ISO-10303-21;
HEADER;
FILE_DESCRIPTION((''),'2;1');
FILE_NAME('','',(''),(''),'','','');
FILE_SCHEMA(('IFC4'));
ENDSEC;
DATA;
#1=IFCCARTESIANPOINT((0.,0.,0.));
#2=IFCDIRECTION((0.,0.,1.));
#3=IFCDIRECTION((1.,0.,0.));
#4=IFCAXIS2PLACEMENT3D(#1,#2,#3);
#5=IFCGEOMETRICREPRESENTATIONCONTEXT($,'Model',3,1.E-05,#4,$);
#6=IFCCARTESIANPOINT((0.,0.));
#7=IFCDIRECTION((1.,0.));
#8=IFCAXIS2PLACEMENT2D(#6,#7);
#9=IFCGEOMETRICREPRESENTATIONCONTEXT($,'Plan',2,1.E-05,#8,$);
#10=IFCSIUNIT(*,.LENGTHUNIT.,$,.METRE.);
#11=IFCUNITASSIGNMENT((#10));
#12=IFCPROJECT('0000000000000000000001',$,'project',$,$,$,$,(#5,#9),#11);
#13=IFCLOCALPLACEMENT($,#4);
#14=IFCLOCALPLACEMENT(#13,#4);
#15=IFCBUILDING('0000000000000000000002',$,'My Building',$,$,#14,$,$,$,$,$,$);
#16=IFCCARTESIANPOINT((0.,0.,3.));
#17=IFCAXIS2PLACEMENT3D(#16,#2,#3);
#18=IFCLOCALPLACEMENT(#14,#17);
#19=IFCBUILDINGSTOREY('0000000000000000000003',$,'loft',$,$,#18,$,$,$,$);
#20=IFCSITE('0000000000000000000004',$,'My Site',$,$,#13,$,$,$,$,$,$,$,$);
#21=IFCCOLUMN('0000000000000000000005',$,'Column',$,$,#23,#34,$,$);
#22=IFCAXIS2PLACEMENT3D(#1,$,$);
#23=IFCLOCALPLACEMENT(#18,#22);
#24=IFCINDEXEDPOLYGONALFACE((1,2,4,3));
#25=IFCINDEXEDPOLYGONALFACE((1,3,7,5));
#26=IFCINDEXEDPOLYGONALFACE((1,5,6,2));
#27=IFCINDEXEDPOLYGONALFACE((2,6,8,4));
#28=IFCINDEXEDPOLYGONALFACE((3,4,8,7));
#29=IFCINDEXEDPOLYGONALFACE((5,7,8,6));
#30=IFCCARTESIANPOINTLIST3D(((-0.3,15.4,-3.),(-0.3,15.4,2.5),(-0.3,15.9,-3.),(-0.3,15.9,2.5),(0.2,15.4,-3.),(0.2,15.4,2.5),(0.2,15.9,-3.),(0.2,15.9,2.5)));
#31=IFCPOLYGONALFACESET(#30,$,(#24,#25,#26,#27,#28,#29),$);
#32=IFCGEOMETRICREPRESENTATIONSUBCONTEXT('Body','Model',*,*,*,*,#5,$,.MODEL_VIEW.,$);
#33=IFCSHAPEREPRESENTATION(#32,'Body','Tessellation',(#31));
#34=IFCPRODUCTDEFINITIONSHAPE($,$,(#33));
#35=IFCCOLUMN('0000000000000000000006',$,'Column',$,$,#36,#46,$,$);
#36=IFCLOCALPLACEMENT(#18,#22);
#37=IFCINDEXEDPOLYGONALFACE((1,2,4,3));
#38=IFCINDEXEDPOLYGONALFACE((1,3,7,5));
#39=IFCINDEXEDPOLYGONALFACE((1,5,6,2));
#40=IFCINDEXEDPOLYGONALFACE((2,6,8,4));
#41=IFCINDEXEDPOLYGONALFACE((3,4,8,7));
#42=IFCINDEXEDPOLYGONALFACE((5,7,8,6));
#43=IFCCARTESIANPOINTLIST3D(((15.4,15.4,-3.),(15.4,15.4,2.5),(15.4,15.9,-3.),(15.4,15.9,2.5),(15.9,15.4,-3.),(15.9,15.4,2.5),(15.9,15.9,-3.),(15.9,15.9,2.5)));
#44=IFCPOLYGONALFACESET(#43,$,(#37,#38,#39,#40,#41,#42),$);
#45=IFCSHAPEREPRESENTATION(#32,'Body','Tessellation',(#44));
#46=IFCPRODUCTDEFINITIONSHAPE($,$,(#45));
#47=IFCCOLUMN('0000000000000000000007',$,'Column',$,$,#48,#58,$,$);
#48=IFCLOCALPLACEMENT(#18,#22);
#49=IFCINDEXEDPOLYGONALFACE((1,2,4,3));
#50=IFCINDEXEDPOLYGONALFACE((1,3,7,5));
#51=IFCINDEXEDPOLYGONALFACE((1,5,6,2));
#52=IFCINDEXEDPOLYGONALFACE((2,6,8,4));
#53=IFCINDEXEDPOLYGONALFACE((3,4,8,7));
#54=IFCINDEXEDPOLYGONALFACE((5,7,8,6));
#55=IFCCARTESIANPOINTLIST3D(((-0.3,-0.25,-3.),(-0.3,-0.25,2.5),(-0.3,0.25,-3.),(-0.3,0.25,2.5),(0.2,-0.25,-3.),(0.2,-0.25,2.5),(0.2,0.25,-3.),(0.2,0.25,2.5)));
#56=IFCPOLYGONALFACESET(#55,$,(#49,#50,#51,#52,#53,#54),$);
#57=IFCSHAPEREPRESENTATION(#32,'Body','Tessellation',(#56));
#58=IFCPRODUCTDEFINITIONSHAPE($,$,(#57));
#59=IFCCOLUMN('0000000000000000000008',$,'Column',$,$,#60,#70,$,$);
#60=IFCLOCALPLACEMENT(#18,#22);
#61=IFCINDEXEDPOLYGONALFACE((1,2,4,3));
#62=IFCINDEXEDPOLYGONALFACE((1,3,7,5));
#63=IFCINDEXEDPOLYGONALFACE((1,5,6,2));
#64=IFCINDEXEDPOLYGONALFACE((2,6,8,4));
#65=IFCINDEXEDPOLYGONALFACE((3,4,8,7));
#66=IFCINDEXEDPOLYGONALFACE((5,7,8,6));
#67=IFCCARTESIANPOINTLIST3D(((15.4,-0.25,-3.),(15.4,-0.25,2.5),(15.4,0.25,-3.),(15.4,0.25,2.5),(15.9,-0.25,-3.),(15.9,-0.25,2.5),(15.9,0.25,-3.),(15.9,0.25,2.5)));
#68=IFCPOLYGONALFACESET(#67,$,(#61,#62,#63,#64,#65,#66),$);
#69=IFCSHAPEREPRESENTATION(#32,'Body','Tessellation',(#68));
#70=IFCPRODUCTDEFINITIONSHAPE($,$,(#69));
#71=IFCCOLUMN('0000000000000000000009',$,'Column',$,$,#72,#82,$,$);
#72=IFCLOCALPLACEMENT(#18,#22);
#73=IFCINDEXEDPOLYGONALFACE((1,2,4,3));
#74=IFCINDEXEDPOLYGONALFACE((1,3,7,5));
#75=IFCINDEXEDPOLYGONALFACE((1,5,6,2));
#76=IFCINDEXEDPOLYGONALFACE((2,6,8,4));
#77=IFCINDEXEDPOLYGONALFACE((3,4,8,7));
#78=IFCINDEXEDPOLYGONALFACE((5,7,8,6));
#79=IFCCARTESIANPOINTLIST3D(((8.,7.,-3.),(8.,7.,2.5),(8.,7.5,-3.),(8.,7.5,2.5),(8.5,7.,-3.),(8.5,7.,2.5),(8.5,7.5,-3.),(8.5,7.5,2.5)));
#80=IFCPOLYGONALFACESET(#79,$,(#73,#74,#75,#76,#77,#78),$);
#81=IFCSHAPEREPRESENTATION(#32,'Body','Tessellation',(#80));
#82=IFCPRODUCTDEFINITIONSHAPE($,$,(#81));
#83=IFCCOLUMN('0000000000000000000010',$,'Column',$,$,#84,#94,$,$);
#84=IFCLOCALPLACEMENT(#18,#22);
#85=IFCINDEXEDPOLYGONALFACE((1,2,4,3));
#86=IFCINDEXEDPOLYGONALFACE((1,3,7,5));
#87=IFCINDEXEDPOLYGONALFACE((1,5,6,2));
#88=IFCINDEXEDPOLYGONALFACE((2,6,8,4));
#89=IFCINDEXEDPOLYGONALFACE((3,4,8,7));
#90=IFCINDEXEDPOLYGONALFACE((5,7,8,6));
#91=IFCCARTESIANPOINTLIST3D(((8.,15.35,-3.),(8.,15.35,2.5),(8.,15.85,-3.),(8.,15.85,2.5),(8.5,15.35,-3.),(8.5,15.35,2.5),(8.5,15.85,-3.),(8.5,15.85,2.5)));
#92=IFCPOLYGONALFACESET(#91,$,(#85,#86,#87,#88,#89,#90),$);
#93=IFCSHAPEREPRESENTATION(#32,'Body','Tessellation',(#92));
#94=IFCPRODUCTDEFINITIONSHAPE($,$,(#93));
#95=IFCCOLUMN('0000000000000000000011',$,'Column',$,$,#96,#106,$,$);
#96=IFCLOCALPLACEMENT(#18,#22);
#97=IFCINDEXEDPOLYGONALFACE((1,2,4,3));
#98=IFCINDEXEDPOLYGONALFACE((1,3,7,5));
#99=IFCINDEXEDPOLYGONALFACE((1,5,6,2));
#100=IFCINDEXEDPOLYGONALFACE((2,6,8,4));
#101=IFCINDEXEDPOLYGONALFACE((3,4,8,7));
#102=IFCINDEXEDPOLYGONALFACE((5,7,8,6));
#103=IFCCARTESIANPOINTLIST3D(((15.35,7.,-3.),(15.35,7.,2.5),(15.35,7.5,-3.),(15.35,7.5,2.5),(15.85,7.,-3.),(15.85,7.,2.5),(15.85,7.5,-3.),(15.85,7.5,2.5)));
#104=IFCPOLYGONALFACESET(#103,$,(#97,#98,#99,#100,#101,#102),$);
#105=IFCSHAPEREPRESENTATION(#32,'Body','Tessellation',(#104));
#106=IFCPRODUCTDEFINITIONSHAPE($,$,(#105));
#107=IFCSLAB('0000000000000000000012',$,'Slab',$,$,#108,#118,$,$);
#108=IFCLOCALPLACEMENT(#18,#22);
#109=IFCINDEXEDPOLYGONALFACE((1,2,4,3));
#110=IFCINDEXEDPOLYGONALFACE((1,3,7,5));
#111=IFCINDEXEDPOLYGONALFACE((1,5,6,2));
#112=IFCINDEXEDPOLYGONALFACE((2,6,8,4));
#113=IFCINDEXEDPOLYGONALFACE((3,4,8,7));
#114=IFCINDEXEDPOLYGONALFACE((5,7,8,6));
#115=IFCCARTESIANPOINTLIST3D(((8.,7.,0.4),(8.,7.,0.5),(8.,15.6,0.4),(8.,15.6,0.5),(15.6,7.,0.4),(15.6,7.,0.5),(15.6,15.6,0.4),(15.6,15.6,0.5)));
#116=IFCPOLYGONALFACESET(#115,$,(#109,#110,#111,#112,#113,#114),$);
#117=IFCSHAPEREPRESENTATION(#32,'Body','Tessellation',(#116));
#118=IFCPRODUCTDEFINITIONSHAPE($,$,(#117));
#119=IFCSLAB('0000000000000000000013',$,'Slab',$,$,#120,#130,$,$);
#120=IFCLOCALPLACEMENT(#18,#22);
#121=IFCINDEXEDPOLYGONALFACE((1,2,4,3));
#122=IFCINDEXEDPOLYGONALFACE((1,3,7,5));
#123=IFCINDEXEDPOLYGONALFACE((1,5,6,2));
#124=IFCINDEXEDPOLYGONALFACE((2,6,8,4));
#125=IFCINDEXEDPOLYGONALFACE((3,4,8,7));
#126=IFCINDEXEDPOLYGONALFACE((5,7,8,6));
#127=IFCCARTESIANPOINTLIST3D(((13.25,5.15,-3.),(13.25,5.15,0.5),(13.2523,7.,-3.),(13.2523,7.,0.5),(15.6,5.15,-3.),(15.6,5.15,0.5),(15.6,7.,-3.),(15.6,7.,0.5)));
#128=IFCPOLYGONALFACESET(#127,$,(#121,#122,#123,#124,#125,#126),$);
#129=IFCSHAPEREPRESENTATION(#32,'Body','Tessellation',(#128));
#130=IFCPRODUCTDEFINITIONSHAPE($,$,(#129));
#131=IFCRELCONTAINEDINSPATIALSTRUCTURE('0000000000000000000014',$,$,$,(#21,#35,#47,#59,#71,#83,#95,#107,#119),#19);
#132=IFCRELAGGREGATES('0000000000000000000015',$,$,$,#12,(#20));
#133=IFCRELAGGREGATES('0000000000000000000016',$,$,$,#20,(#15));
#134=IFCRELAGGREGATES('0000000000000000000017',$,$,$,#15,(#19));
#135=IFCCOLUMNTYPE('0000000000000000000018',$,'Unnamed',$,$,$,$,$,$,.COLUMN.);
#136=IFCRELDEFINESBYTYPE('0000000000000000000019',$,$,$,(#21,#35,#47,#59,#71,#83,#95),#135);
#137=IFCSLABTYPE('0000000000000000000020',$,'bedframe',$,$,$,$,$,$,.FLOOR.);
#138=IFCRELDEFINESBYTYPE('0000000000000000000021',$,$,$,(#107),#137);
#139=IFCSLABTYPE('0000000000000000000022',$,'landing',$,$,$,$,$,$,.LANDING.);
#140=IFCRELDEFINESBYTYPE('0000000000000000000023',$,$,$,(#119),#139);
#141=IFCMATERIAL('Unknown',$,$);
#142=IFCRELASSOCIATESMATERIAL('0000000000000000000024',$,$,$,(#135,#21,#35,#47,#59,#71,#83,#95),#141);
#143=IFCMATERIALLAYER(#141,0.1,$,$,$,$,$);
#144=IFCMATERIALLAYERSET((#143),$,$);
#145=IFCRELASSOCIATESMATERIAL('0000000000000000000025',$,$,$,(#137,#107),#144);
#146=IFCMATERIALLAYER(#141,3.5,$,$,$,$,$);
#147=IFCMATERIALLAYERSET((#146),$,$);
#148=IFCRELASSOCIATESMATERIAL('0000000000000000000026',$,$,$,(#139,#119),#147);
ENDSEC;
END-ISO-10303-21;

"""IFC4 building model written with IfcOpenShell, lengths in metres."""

from ifc_helpers import new_model, si_unit, frame, origin_with_axes, origin_2d_with_axis, place, context, subcontext, project, spatial, indexed_curve, rectangle, outline, extrude, material, layer, layer_set, layer_usage, material_profile, profile_set, profile_usage, type_object, element, save


model = new_model("IFC4")

# Units and contexts
model_context = context("Model", 3, precision=1e-05, world=origin_with_axes())
plan_context = context("Plan", 2, precision=1e-05, world=origin_2d_with_axis())
body_context_1 = subcontext(model_context, "Body", "Model", "MODEL_VIEW")
ifc_project = project(units=[si_unit("LENGTHUNIT", "METRE")], contexts=[model_context, plan_context])

# Site, building, storey
site_placement = place(None, origin_with_axes())
site = spatial("IfcSite", under=ifc_project, at=site_placement, Name="My Site")
building_placement = place(site_placement, origin_with_axes())
building = spatial("IfcBuilding", under=site, at=building_placement, Name="My Building")
storey_placement = place(building_placement, frame((0.0, 0.0, 3.0), z_axis=(0.0, 0.0, 1.0), x_axis=(1.0, 0.0, 0.0)))
storey = spatial("IfcBuildingStorey", under=building, at=storey_placement, Name="loft")

# Columns
ifc_material = material(Name="Unknown")
ifc_material_profile = material_profile(ifc_material, rectangle(XDim=0.5, YDim=0.5))
ifc_profile_set = profile_set([ifc_material_profile])
ifc_profile_usage_1 = profile_usage(ifc_profile_set, cardinal=5)
column_type = type_object("IfcColumnType", Name="Unnamed", PredefinedType="COLUMN", material=ifc_profile_set)
column_1_placement = place(storey_placement, frame((-0.05, 15.65, -3.0), z_axis=(0.0, 0.0, 1.0), x_axis=(1.0, 0.0, 0.0)))
element("IfcColumn", 1, at=column_1_placement, inside=storey, type_object=column_type, material=ifc_profile_usage_1, Name="Column", context=body_context_1, shape_type="SweptSolid", body=[
    extrude(rectangle(XDim=0.5, YDim=0.5), origin_with_axes(), (0.0, 0.0, 1.0), 5.5),
])
ifc_profile_usage_2 = profile_usage(ifc_profile_set, cardinal=5)
column_2_placement = place(storey_placement, frame((15.65, 15.65, -3.0), z_axis=(0.0, 0.0, 1.0), x_axis=(1.0, 0.0, 0.0)))
element("IfcColumn", 2, at=column_2_placement, inside=storey, type_object=column_type, material=ifc_profile_usage_2, Name="Column", context=body_context_1, shape_type="SweptSolid", body=[
    extrude(rectangle(XDim=0.5, YDim=0.5), origin_with_axes(), (0.0, 0.0, 1.0), 5.5),
])
ifc_profile_usage_3 = profile_usage(ifc_profile_set, cardinal=5)
column_3_placement = place(storey_placement, frame((-0.05, 0.0, -3.0), z_axis=(0.0, 0.0, 1.0), x_axis=(1.0, 0.0, 0.0)))
element("IfcColumn", 3, at=column_3_placement, inside=storey, type_object=column_type, material=ifc_profile_usage_3, Name="Column", context=body_context_1, shape_type="SweptSolid", body=[
    extrude(rectangle(XDim=0.5, YDim=0.5), origin_with_axes(), (0.0, 0.0, 1.0), 5.5),
])
ifc_profile_usage_4 = profile_usage(ifc_profile_set, cardinal=5)
column_4_placement = place(storey_placement, frame((15.65, 0.0, -3.0), z_axis=(0.0, 0.0, 1.0), x_axis=(1.0, 0.0, 0.0)))
element("IfcColumn", 4, at=column_4_placement, inside=storey, type_object=column_type, material=ifc_profile_usage_4, Name="Column", context=body_context_1, shape_type="SweptSolid", body=[
    extrude(rectangle(XDim=0.5, YDim=0.5), origin_with_axes(), (0.0, 0.0, 1.0), 5.5),
])
ifc_profile_usage_5 = profile_usage(ifc_profile_set, cardinal=5)
column_5_placement = place(storey_placement, frame((8.25, 7.25, -3.0), z_axis=(0.0, 0.0, 1.0), x_axis=(1.0, 0.0, 0.0)))
element("IfcColumn", 5, at=column_5_placement, inside=storey, type_object=column_type, material=ifc_profile_usage_5, Name="Column", context=body_context_1, shape_type="SweptSolid", body=[
    extrude(rectangle(XDim=0.5, YDim=0.5), origin_with_axes(), (0.0, 0.0, 1.0), 5.5),
])
ifc_profile_usage_6 = profile_usage(ifc_profile_set, cardinal=5)
column_6_placement = place(storey_placement, frame((8.25, 15.6, -3.0), z_axis=(0.0, 0.0, 1.0), x_axis=(1.0, 0.0, 0.0)))
element("IfcColumn", 6, at=column_6_placement, inside=storey, type_object=column_type, material=ifc_profile_usage_6, Name="Column", context=body_context_1, shape_type="SweptSolid", body=[
    extrude(rectangle(XDim=0.5, YDim=0.5), origin_with_axes(), (0.0, 0.0, 1.0), 5.5),
])
ifc_profile_usage_7 = profile_usage(ifc_profile_set, cardinal=5)
column_7_placement = place(storey_placement, frame((15.6, 7.25, -3.0), z_axis=(0.0, 0.0, 1.0), x_axis=(1.0, 0.0, 0.0)))
element("IfcColumn", 7, at=column_7_placement, inside=storey, type_object=column_type, material=ifc_profile_usage_7, Name="Column", context=body_context_1, shape_type="SweptSolid", body=[
    extrude(rectangle(XDim=0.5, YDim=0.5), origin_with_axes(), (0.0, 0.0, 1.0), 5.5),
])

# Slabs
ifc_layer_1 = layer(ifc_material, 0.1)
ifc_layer_set_1 = layer_set([ifc_layer_1])
ifc_layer_usage_1 = layer_usage(ifc_layer_set_1, "AXIS3", "POSITIVE", -0.1)
slab_type_1 = type_object("IfcSlabType", Name="bedframe", PredefinedType="FLOOR", material=ifc_layer_set_1)
slab_1_placement = place(storey_placement, frame((15.6, 15.6, 0.5), z_axis=(0.0, 0.0, 1.0), x_axis=(1.0, 0.0, 0.0)))
element("IfcSlab", 8, at=slab_1_placement, inside=storey, type_object=slab_type_1, material=ifc_layer_usage_1, Name="Slab", context=body_context_1, shape_type="SweptSolid", body=[
    extrude(outline(indexed_curve([(0.0, -8.6), (-7.6, -8.6), (-7.6, 0.0), (0.0, 0.0), (0.0, -8.6)])), frame((0.0, 0.0, -0.1), z_axis=(0.0, 0.0, 1.0), x_axis=(1.0, 0.0, 0.0)), (0.0, 0.0, 1.0), 0.1),
])
ifc_layer_2 = layer(ifc_material, 3.5)
ifc_layer_set_2 = layer_set([ifc_layer_2])
ifc_layer_usage_2 = layer_usage(ifc_layer_set_2, "AXIS3", "POSITIVE", -0.1)
slab_type_2 = type_object("IfcSlabType", Name="landing", PredefinedType="LANDING", material=ifc_layer_set_2)
slab_2_placement = place(storey_placement, frame((13.2523, 7.0, -2.9), z_axis=(0.0, 0.0, 1.0), x_axis=(1.0, 0.0, 0.0)))
element("IfcSlab", 9, at=slab_2_placement, inside=storey, type_object=slab_type_2, material=ifc_layer_usage_2, Name="Slab", context=body_context_1, shape_type="SweptSolid", body=[
    extrude(outline(indexed_curve([(-0.0023, -1.85), (2.3477, -1.85), (2.3477, 0.0), (0.0, 0.0), (-0.0023, -1.85)])), frame((0.0, 0.0, -0.1), z_axis=(0.0, 0.0, 1.0), x_axis=(1.0, 0.0, 0.0)), (0.0, 0.0, 1.0), 3.5),
])

save(model, "model.ifc")
